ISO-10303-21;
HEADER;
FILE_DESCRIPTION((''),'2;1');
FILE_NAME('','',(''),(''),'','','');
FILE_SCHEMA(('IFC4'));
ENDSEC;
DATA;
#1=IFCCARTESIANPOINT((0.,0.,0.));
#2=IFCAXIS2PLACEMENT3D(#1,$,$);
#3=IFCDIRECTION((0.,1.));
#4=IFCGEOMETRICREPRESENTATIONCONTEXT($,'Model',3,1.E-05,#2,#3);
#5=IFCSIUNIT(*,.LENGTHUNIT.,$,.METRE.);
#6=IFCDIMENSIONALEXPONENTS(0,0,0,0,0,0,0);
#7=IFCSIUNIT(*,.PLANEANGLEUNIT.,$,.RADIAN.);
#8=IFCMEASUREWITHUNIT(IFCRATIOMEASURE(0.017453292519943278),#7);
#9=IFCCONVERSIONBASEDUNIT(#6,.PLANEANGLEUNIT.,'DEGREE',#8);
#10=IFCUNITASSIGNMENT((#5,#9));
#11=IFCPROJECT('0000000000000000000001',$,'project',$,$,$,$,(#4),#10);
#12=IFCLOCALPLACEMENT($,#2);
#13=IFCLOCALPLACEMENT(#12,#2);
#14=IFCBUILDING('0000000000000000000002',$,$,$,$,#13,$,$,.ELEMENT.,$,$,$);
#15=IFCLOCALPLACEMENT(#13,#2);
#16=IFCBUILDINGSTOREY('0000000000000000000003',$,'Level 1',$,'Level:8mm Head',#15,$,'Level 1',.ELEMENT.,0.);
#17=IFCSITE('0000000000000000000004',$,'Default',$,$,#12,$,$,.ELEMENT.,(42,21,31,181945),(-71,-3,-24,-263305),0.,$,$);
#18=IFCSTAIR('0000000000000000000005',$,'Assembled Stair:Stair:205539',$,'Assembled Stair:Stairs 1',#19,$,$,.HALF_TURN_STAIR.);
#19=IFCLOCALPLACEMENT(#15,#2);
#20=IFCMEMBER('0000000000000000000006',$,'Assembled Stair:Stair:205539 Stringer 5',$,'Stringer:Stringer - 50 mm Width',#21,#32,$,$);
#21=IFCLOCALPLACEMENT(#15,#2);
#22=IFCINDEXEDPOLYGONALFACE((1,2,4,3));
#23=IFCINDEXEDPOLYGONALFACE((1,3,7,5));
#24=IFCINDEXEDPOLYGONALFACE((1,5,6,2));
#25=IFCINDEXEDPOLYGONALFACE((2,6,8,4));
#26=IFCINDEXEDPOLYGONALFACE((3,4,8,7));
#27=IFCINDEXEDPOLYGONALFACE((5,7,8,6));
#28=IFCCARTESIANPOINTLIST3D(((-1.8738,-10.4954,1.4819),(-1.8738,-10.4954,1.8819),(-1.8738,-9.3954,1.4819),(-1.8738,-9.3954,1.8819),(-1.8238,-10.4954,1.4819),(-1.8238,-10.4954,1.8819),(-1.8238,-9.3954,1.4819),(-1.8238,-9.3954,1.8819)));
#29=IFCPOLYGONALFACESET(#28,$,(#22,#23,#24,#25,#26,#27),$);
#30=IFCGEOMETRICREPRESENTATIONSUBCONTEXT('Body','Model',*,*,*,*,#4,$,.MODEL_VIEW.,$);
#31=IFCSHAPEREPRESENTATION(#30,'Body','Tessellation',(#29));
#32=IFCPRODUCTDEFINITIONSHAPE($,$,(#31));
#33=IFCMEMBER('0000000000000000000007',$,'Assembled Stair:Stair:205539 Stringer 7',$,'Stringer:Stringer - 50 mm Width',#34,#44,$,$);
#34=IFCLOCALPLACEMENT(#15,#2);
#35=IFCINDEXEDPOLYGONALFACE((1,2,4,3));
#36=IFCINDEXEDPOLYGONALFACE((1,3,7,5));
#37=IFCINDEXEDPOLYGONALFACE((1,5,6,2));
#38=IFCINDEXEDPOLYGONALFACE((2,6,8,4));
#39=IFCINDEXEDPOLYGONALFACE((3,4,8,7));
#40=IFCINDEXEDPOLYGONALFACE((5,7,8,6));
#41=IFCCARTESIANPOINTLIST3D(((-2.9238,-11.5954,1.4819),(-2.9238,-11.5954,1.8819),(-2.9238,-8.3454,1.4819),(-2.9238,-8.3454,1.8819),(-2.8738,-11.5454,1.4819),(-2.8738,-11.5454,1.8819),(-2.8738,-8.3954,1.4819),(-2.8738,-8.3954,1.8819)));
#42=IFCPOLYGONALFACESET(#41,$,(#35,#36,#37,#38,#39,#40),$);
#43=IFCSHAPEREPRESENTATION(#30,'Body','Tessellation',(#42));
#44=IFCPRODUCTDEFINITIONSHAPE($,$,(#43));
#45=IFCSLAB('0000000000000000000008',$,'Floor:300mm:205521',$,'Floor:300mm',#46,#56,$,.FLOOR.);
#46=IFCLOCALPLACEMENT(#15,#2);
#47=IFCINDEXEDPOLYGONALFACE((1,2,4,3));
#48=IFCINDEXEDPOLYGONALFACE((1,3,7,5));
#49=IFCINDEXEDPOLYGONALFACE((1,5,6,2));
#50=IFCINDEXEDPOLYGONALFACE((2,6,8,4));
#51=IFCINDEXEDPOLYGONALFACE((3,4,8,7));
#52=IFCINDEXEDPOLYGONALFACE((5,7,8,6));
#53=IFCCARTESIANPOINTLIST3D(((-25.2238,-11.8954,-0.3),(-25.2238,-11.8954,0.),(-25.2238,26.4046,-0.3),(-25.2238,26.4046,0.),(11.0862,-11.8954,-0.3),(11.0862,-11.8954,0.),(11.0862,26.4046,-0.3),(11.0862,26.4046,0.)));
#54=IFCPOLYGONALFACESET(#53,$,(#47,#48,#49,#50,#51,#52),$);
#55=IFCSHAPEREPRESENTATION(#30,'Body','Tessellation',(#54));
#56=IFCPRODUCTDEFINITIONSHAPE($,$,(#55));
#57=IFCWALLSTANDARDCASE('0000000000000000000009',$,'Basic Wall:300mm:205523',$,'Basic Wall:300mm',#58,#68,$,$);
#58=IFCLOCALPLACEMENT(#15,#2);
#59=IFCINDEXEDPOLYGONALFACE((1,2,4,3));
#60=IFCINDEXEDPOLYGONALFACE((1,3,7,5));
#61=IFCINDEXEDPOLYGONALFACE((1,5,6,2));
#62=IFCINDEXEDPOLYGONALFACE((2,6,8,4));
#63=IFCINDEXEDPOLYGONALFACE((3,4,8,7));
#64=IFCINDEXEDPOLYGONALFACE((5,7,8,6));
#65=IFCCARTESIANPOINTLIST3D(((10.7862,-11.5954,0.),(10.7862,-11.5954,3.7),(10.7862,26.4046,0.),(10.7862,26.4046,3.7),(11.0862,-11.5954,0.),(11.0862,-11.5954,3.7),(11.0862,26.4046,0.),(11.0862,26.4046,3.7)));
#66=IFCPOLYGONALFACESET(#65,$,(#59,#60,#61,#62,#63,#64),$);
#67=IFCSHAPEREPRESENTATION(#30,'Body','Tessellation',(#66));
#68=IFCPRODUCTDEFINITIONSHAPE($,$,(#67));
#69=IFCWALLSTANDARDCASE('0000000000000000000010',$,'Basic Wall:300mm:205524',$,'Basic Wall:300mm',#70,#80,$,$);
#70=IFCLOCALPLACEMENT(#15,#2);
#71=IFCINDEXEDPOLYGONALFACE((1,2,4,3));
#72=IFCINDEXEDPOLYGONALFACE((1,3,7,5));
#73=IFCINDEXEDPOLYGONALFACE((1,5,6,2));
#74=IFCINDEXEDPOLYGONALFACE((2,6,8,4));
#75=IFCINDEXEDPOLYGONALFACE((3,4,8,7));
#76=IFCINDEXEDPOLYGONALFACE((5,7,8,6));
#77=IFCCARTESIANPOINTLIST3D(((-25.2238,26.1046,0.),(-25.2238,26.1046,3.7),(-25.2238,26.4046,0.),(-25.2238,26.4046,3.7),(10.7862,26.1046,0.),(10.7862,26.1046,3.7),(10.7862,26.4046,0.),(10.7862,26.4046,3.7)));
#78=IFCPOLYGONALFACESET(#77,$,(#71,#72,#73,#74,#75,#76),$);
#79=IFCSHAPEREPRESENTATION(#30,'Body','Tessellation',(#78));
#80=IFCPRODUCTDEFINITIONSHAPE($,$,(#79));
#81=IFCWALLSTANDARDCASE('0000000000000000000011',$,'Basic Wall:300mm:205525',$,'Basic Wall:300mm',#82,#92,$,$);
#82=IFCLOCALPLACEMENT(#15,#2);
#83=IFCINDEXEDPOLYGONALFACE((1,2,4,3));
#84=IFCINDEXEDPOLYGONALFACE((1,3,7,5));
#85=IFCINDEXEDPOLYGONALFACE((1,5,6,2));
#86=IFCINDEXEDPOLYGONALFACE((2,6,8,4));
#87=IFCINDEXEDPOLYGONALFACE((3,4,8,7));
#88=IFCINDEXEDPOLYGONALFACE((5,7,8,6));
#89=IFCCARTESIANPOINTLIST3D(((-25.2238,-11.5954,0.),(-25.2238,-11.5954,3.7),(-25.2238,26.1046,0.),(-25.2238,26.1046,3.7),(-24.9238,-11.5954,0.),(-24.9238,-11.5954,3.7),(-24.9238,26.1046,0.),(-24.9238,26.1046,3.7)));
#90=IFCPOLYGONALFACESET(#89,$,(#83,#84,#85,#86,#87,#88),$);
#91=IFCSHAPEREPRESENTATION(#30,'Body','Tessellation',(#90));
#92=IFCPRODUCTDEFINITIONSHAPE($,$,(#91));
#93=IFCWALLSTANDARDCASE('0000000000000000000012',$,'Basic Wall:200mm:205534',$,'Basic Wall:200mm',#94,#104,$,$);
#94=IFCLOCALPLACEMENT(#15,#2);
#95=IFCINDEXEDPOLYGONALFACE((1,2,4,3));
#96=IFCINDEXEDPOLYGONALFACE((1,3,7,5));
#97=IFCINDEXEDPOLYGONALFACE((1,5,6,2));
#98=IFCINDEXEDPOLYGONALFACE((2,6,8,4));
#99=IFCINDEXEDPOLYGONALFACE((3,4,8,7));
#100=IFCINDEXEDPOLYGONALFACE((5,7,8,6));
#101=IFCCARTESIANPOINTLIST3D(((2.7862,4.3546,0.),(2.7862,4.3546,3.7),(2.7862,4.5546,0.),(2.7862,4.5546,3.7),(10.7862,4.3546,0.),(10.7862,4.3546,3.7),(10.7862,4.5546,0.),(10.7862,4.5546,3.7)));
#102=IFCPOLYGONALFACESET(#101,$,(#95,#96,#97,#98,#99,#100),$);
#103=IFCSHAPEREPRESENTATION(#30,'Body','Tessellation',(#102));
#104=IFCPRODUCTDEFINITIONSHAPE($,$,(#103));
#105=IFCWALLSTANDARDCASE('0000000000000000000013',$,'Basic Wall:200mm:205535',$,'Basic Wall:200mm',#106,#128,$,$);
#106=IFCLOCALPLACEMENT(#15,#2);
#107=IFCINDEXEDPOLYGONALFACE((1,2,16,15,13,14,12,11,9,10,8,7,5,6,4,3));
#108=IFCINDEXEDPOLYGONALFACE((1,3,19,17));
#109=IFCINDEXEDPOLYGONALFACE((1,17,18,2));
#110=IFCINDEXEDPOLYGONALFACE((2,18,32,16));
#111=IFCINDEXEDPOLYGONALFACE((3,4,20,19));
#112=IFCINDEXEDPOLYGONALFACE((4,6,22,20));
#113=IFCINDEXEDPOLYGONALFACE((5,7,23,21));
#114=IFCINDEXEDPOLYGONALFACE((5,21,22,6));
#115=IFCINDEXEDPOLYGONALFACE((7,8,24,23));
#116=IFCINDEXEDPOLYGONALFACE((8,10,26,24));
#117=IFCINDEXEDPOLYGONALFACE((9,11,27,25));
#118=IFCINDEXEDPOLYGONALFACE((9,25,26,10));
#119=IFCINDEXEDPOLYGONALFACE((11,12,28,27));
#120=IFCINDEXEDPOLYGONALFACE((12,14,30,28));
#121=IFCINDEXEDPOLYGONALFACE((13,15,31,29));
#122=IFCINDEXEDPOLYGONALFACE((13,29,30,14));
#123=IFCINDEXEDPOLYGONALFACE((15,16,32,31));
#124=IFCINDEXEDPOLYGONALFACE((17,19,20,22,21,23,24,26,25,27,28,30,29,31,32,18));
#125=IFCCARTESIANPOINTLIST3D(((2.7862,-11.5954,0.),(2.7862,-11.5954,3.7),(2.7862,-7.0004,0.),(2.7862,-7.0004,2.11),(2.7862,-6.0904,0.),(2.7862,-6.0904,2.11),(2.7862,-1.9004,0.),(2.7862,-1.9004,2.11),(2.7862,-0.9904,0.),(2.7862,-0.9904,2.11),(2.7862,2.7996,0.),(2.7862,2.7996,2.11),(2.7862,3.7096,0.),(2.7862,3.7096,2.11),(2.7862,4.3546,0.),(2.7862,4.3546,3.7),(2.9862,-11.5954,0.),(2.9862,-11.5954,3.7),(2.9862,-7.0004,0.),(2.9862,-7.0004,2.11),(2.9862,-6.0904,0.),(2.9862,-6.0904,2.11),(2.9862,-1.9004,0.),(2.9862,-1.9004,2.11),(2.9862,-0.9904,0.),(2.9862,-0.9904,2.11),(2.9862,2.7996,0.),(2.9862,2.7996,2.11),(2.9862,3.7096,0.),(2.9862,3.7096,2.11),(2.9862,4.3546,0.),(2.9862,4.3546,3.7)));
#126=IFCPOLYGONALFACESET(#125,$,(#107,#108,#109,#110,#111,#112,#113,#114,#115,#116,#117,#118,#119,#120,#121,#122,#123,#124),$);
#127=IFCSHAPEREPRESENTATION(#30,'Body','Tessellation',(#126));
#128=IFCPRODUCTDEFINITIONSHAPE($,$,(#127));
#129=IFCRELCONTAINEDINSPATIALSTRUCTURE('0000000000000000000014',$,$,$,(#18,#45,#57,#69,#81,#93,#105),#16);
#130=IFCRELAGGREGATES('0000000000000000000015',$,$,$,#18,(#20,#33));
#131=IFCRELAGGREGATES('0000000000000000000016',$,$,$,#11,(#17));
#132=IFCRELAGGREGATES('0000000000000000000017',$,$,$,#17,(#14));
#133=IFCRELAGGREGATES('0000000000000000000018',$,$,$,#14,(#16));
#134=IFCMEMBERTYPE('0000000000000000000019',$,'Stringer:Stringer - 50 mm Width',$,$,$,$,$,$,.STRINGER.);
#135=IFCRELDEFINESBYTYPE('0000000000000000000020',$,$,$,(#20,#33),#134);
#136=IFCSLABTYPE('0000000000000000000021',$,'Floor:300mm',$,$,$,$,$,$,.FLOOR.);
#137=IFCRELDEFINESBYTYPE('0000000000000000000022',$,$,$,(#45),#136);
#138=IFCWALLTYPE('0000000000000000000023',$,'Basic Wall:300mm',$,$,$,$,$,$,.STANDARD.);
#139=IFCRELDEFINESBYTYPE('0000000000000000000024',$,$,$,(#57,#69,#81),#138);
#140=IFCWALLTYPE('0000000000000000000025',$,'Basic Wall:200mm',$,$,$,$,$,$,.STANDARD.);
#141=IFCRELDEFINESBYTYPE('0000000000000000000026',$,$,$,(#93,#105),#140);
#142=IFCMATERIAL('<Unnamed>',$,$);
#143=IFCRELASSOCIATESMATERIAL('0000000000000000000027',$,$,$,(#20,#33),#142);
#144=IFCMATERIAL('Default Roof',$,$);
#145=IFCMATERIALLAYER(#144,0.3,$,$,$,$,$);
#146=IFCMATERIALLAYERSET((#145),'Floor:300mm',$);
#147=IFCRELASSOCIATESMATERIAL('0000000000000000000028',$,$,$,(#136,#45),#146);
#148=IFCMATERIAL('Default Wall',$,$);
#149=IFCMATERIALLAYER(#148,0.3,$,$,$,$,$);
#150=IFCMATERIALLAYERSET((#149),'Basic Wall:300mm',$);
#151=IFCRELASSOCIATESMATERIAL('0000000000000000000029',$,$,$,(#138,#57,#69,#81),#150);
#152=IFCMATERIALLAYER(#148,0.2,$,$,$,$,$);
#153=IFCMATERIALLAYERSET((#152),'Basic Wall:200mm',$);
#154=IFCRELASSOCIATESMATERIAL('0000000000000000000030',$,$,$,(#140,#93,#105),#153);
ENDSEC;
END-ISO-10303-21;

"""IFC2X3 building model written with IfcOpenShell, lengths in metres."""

from ifc_helpers import new_model, entity, si_unit, converted_unit, direction, frame, frame_2d, origin, origin_2d_with_axis, place, context, subcontext, project, spatial, polyline, rectangle, outline, extrude, clip, bounded_halfspace, material, layer, layer_set, layer_usage, type_object, element, aggregate, save


model = new_model("IFC2X3")

# Units and contexts
model_context = context("Model", 3, precision=1e-05, world=origin(), true_north=direction((0.0, 1.0)))
body_context = subcontext(model_context, "Body", "Model", "MODEL_VIEW")
ifc_project = project(units=[si_unit("LENGTHUNIT", "METRE"), converted_unit("PLANEANGLEUNIT", "DEGREE", entity("IfcRatioMeasure", 0.017453292519943278), si_unit("PLANEANGLEUNIT", "RADIAN"), dimensions=[0, 0, 0, 0, 0, 0, 0])], contexts=[model_context])

# Site, building, storey
site_placement = place(None, origin())
site = spatial("IfcSite", under=ifc_project, at=site_placement, Name="Default", CompositionType="ELEMENT", RefLatitude=(42, 21, 31, 181945), RefLongitude=(-71, -3, -24, -263305), RefElevation=0.0)
building_placement = place(site_placement, origin())
building = spatial("IfcBuilding", under=site, at=building_placement, CompositionType="ELEMENT")
storey_placement = place(building_placement, origin())
storey = spatial("IfcBuildingStorey", under=building, at=storey_placement, Name="Level 1", ObjectType="Level:8mm Head", LongName="Level 1", CompositionType="ELEMENT", Elevation=0.0)

# Stair, members
stair_placement = place(storey_placement, origin())
stair = element("IfcStair", 1, at=stair_placement, inside=storey, Name="Assembled Stair:Stair:205539", ObjectType="Assembled Stair:Stairs 1", ShapeType="HALF_TURN_STAIR")
ifc_material_1 = material(Name="<Unnamed>")
member_type = type_object("IfcMemberType", Name="Stringer:Stringer - 50 mm Width", PredefinedType="STRINGER")
member_1_placement = place(stair_placement, origin())
member_1 = element("IfcMember", 2, at=member_1_placement, type_object=member_type, material=ifc_material_1, Name="Assembled Stair:Stair:205539 Stringer 5", ObjectType="Stringer:Stringer - 50 mm Width", context=body_context, shape_type="SweptSolid", body=[
    extrude(rectangle(XDim=1.1, YDim=0.05, at=frame_2d((0.0, 0.0), x_axis=(1.0, 0.0))), frame((-1.8488, -9.9454, 1.4819), z_axis=(0.0, 0.0, 1.0), x_axis=(0.0, 1.0, 0.0)), (0.0, 0.0, 1.0), 0.4),
])
member_2_placement = place(stair_placement, origin())
member_2 = element("IfcMember", 3, at=member_2_placement, type_object=member_type, material=ifc_material_1, Name="Assembled Stair:Stair:205539 Stringer 7", ObjectType="Stringer:Stringer - 50 mm Width", context=body_context, shape_type="SweptSolid", body=[
    extrude(outline(polyline([(-1.625, -0.025), (1.625, -0.025), (1.575, 0.025), (-1.575, 0.025), (-1.625, -0.025)])), frame((-2.8988, -9.9704, 1.4819), z_axis=(0.0, 0.0, 1.0), x_axis=(0.0, -1.0, 0.0)), (0.0, 0.0, 1.0), 0.4),
])

# Slab
ifc_material_2 = material(Name="Default Roof")
ifc_layer_1 = layer(ifc_material_2, 0.3)
ifc_layer_set_1 = layer_set([ifc_layer_1], Name="Floor:300mm")
ifc_layer_usage_1 = layer_usage(ifc_layer_set_1, "AXIS3", "POSITIVE", 0.0)
slab_type_1 = type_object("IfcSlabType", Name="Floor:300mm", PredefinedType="FLOOR", material=ifc_layer_set_1)
slab_1_placement = place(storey_placement, origin())
element("IfcSlab", 4, at=slab_1_placement, inside=storey, type_object=slab_type_1, material=ifc_layer_usage_1, Name="Floor:300mm:205521", ObjectType="Floor:300mm", PredefinedType="FLOOR", context=body_context, shape_type="SweptSolid", body=[
    extrude(rectangle(XDim=38.3, YDim=36.31, at=origin_2d_with_axis()), frame((-7.0688, 7.2546, 0.0), z_axis=(0.0, 0.0, -1.0), x_axis=(0.0, 1.0, 0.0)), (0.0, 0.0, 1.0), 0.3),
])

# Walls
ifc_material_3 = material(Name="Default Wall")
ifc_layer_2 = layer(ifc_material_3, 0.3)
ifc_layer_set_2 = layer_set([ifc_layer_2], Name="Basic Wall:300mm")
wall_type_1 = type_object("IfcWallType", Name="Basic Wall:300mm", PredefinedType="STANDARD", material=ifc_layer_set_2)
ifc_layer_usage_2 = layer_usage(ifc_layer_set_2, "AXIS2", "NEGATIVE", 0.15)
wall_1_placement = place(storey_placement, frame((10.9362, 26.4046, 0.0), z_axis=(0.0, 0.0, 1.0), x_axis=(0.0, -1.0, 0.0)))
element("IfcWallStandardCase", 5, at=wall_1_placement, inside=storey, type_object=wall_type_1, material=ifc_layer_usage_2, Name="Basic Wall:300mm:205523", ObjectType="Basic Wall:300mm", context=body_context, shape_type="Clipping", body=[
    clip(extrude(rectangle(XDim=38.0, YDim=0.3, at=frame_2d((19.0, 0.0), x_axis=(-1.0, 0.0))), origin(), (0.0, 0.0, 1.0), 3.7), bounded_halfspace(frame((0.0, -0.15, 3.7), z_axis=(0.0, 0.0, -1.0), x_axis=(1.0, 0.0, 0.0)), True, frame((0.0, -0.15, 3.7), z_axis=(0.0, 0.0, -1.0), x_axis=(1.0, 0.0, 0.0)), polyline([(0.0, 0.0), (0.0, -0.3), (38.0, -0.3), (38.0, 0.0), (0.0, 0.0)]))),
])
ifc_layer_usage_3 = layer_usage(ifc_layer_set_2, "AXIS2", "NEGATIVE", 0.15)
wall_2_placement = place(storey_placement, frame((-25.2238, 26.2546, 0.0)))
element("IfcWallStandardCase", 6, at=wall_2_placement, inside=storey, type_object=wall_type_1, material=ifc_layer_usage_3, Name="Basic Wall:300mm:205524", ObjectType="Basic Wall:300mm", context=body_context, shape_type="Clipping", body=[
    clip(extrude(rectangle(XDim=36.01, YDim=0.3, at=frame_2d((18.005, 0.0), x_axis=(-1.0, 0.0))), origin(), (0.0, 0.0, 1.0), 3.7), bounded_halfspace(frame((0.0, -0.15, 3.7), z_axis=(0.0, 0.0, -1.0), x_axis=(0.0, -1.0, 0.0)), True, frame((0.0, -0.15, 3.7), z_axis=(0.0, 0.0, -1.0), x_axis=(0.0, -1.0, 0.0)), polyline([(0.0, 0.0), (-0.3, 0.0), (-0.3, -36.01), (0.0, -36.01), (0.0, -0.3), (0.0, 0.0)]))),
])
ifc_layer_usage_4 = layer_usage(ifc_layer_set_2, "AXIS2", "NEGATIVE", 0.15)
wall_3_placement = place(storey_placement, frame((-25.0738, -11.5954, 0.0), z_axis=(0.0, 0.0, 1.0), x_axis=(0.0, 1.0, 0.0)))
element("IfcWallStandardCase", 7, at=wall_3_placement, inside=storey, type_object=wall_type_1, material=ifc_layer_usage_4, Name="Basic Wall:300mm:205525", ObjectType="Basic Wall:300mm", context=body_context, shape_type="Clipping", body=[
    clip(extrude(rectangle(XDim=37.7, YDim=0.3, at=frame_2d((18.85, 0.0), x_axis=(-1.0, 0.0))), origin(), (0.0, 0.0, 1.0), 3.7), bounded_halfspace(frame((0.0, -0.15, 3.7), z_axis=(0.0, 0.0, -1.0), x_axis=(-1.0, 0.0, 0.0)), True, frame((0.0, -0.15, 3.7), z_axis=(0.0, 0.0, -1.0), x_axis=(-1.0, 0.0, 0.0)), polyline([(0.0, 0.0), (0.0, 0.3), (-37.7, 0.3), (-37.7, 0.0), (0.0, 0.0)]))),
])
ifc_layer_3 = layer(ifc_material_3, 0.2)
ifc_layer_set_3 = layer_set([ifc_layer_3], Name="Basic Wall:200mm")
ifc_layer_usage_5 = layer_usage(ifc_layer_set_3, "AXIS2", "NEGATIVE", 0.1)
wall_type_2 = type_object("IfcWallType", Name="Basic Wall:200mm", PredefinedType="STANDARD", material=ifc_layer_set_3)
wall_4_placement = place(storey_placement, frame((10.7862, 4.4546, 0.0), z_axis=(0.0, 0.0, 1.0), x_axis=(-1.0, 0.0, 0.0)))
element("IfcWallStandardCase", 8, at=wall_4_placement, inside=storey, type_object=wall_type_2, material=ifc_layer_usage_5, Name="Basic Wall:200mm:205534", ObjectType="Basic Wall:200mm", context=body_context, shape_type="Clipping", body=[
    clip(extrude(rectangle(XDim=8.0, YDim=0.2, at=frame_2d((4.0, 0.0), x_axis=(-1.0, 0.0))), origin(), (0.0, 0.0, 1.0), 3.7), bounded_halfspace(frame((0.0, -0.1, 3.7), z_axis=(0.0, 0.0, -1.0), x_axis=(0.0, 1.0, 0.0)), True, frame((0.0, -0.1, 3.7), z_axis=(0.0, 0.0, -1.0), x_axis=(0.0, 1.0, 0.0)), polyline([(0.0, 0.0), (0.2, 0.0), (0.2, 7.8), (0.2, 8.0), (0.0, 8.0), (0.0, 0.0)]))),
])

# Wall, openings
ifc_layer_usage_6 = layer_usage(ifc_layer_set_3, "AXIS2", "NEGATIVE", 0.1)
wall_5_placement = place(storey_placement, frame((2.8862, 4.3546, 0.0), z_axis=(0.0, 0.0, 1.0), x_axis=(0.0, -1.0, 0.0)))
wall_5 = element("IfcWallStandardCase", 9, at=wall_5_placement, inside=storey, type_object=wall_type_2, material=ifc_layer_usage_6, Name="Basic Wall:200mm:205535", ObjectType="Basic Wall:200mm", context=body_context, shape_type="Clipping", body=[
    clip(extrude(rectangle(XDim=15.95, YDim=0.2, at=frame_2d((7.975, 0.0), x_axis=(-1.0, 0.0))), origin(), (0.0, 0.0, 1.0), 3.7), bounded_halfspace(frame((0.0, -0.1, 3.7), z_axis=(0.0, 0.0, -1.0), x_axis=(1.0, 0.0, 0.0)), True, frame((0.0, -0.1, 3.7), z_axis=(0.0, 0.0, -1.0), x_axis=(1.0, 0.0, 0.0)), polyline([(0.0, 0.0), (0.0, -0.2), (15.95, -0.2), (15.95, 0.0), (0.0, 0.0)]))),
])
opening_1_placement = place(wall_5_placement, frame((0.645, -0.1, 0.0)))
element("IfcOpeningElement", 10, at=opening_1_placement, cuts=wall_5, ObjectType="Opening", context=body_context, shape_type="SweptSolid", body=[
    extrude(rectangle(XDim=2.11, YDim=0.91, at=frame_2d((1.055, 0.455), x_axis=(1.0, 0.0))), frame((0.0, 0.0, 0.0), z_axis=(0.0, 1.0, 0.0), x_axis=(0.0, 0.0, 1.0)), (0.0, 0.0, 1.0), 0.2),
])
opening_2_placement = place(wall_5_placement, frame((5.345, -0.1, 0.0)))
element("IfcOpeningElement", 11, at=opening_2_placement, cuts=wall_5, ObjectType="Opening", context=body_context, shape_type="SweptSolid", body=[
    extrude(rectangle(XDim=2.11, YDim=0.91, at=frame_2d((1.055, 0.455), x_axis=(1.0, 0.0))), frame((0.0, 0.0, 0.0), z_axis=(0.0, 1.0, 0.0), x_axis=(0.0, 0.0, 1.0)), (0.0, 0.0, 1.0), 0.2),
])
opening_3_placement = place(wall_5_placement, frame((10.445, -0.1, 0.0)))
element("IfcOpeningElement", 12, at=opening_3_placement, cuts=wall_5, ObjectType="Opening", context=body_context, shape_type="SweptSolid", body=[
    extrude(rectangle(XDim=2.11, YDim=0.91, at=frame_2d((1.055, 0.455), x_axis=(1.0, 0.0))), frame((0.0, 0.0, 0.0), z_axis=(0.0, 1.0, 0.0), x_axis=(0.0, 0.0, 1.0)), (0.0, 0.0, 1.0), 0.2),
])

aggregate(stair, [member_1, member_2])

save(model, "model.ifc")
